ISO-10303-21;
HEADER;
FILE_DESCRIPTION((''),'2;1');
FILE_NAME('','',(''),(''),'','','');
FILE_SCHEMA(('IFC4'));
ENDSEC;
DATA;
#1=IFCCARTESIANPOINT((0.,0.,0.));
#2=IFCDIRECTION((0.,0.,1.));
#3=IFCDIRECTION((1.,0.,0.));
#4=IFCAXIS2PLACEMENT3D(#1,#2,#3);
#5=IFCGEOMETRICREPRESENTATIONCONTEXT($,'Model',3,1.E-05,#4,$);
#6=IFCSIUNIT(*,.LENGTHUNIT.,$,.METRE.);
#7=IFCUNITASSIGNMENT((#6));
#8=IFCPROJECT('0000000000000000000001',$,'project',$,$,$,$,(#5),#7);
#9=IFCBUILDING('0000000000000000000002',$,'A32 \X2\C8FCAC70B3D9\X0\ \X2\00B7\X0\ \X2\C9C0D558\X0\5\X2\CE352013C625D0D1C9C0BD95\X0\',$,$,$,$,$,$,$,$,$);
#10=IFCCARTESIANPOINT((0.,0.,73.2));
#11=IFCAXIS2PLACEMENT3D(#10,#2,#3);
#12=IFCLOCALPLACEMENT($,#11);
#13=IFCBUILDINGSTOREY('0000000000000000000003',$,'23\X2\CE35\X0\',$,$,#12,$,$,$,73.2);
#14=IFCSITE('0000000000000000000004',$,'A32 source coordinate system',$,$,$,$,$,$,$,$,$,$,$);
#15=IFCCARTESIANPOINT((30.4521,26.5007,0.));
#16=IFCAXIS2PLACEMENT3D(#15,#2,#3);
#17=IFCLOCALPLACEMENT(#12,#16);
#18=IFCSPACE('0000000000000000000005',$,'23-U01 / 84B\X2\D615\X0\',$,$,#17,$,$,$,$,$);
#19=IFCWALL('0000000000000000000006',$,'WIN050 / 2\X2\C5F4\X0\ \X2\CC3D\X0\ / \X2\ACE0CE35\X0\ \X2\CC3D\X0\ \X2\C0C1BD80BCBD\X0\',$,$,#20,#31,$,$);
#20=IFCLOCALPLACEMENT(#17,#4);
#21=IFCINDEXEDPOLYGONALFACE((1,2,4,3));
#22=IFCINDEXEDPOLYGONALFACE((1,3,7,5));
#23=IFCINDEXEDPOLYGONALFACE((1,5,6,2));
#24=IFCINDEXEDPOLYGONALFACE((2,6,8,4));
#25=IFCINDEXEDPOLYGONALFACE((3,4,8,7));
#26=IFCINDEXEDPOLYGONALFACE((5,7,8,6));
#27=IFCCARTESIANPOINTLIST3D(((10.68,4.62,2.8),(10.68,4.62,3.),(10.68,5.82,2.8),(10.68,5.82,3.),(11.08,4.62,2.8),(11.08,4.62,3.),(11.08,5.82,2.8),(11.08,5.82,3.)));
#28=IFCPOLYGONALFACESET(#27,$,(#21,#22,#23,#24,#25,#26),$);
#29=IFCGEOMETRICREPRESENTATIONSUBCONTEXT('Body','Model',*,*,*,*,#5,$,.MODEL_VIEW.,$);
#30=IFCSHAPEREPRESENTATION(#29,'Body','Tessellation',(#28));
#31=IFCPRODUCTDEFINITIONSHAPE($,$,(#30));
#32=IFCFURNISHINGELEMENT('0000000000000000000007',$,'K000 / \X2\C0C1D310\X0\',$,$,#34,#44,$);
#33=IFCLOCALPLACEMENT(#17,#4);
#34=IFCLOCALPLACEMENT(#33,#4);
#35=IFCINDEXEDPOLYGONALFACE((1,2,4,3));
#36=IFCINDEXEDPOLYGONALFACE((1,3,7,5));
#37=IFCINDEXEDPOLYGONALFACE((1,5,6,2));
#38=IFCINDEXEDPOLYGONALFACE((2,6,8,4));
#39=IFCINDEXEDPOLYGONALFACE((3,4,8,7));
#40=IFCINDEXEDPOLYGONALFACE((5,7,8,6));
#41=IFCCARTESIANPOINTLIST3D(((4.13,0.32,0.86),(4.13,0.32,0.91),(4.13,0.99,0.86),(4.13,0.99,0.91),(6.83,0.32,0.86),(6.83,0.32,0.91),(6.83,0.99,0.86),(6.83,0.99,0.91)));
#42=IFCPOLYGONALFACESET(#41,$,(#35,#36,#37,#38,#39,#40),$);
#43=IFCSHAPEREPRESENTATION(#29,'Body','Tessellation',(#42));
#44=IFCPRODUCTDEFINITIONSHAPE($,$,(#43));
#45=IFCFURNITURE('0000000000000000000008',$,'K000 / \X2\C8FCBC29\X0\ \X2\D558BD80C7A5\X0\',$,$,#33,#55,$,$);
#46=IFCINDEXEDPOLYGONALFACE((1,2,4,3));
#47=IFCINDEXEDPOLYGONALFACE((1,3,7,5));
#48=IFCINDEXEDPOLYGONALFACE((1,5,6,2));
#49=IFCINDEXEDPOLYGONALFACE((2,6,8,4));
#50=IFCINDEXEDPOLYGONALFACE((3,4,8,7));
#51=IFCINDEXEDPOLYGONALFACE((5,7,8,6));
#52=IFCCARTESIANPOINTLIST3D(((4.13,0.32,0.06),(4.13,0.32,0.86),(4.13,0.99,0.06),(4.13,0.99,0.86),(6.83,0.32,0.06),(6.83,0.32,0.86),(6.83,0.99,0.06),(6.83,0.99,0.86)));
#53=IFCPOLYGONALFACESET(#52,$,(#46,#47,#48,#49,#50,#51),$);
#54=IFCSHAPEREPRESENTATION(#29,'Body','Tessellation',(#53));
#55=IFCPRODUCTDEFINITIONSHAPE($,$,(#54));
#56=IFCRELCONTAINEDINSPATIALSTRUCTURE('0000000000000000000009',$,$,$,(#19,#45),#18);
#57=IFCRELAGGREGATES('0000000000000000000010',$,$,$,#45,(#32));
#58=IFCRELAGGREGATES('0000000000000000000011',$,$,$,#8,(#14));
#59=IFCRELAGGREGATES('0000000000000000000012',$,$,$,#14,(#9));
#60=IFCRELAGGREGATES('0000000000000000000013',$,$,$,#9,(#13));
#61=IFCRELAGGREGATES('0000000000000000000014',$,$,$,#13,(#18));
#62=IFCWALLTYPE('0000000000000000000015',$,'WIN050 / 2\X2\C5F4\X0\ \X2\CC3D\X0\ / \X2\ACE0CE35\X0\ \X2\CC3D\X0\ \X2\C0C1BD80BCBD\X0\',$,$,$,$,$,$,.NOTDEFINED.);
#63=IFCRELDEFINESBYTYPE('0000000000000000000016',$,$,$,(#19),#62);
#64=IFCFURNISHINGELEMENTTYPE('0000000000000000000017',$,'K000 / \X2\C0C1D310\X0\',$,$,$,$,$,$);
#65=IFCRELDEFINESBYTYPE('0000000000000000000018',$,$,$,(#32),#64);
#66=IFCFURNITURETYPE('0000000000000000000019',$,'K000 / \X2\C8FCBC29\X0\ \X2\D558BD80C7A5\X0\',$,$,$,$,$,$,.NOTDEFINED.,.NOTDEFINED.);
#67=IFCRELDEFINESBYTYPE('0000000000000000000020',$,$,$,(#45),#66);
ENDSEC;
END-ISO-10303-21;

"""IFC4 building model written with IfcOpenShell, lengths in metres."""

from ifc_helpers import new_model, si_unit, frame, origin, origin_with_axes, place, context, subcontext, project, spatial, polyline, outline, extrude, source, transform, mapped, type_object, type_shapes, element, aggregate, save


model = new_model("IFC4")

# Units and contexts
model_context = context("Model", 3, precision=1e-05, world=origin_with_axes())
body_context = subcontext(model_context, "Body", "Model", "MODEL_VIEW")
ifc_project = project(units=[si_unit("LENGTHUNIT", "METRE")], contexts=[model_context])

# Site, building, storey, space
site = spatial("IfcSite", under=ifc_project, Name="A32 source coordinate system")
building = spatial("IfcBuilding", under=site, Name="A32 주거동 · 지하5층–옥탑지붕")
storey_placement = place(None, frame((0.0, 0.0, 73.2), z_axis=(0.0, 0.0, 1.0), x_axis=(1.0, 0.0, 0.0)))
storey = spatial("IfcBuildingStorey", under=building, at=storey_placement, Name="23층", Elevation=73.2)
space_placement = place(storey_placement, frame((30.4521, 26.5007, 0.0), z_axis=(0.0, 0.0, 1.0), x_axis=(1.0, 0.0, 0.0)))
space = spatial("IfcSpace", under=storey, at=space_placement, Name="23-U01 / 84B형")

# Wall
wall_type_1 = type_object("IfcWallType", Name="WIN050 / 2열 창 / 고층 창 상부벽", PredefinedType="NOTDEFINED")
shared_shape_1 = source(origin(), body_context, "Body", "SweptSolid", [
    extrude(outline(polyline([(11.08, 4.62), (11.08, 5.82), (10.68, 5.82), (10.68, 4.62), (11.08, 4.62)])), frame((0.0, 0.0, 2.8)), (0.0, 0.0, 1.0), 0.2),
])
type_shapes(wall_type_1, [shared_shape_1])
wall_1_placement = place(space_placement, origin_with_axes())
element("IfcWall", 1, at=wall_1_placement, inside=space, type_object=wall_type_1, Name="WIN050 / 2열 창 / 고층 창 상부벽", context=body_context, shape_type="MappedRepresentation", body=[
    mapped(shared_shape_1, transform((0.0, 0.0, 0.0), scale=1.0)),
])

# Furnishing element
furnishing_element_type = type_object("IfcFurnishingElementType", Name="K000 / 상판")
shared_shape_2 = source(origin(), body_context, "Body", "SweptSolid", [
    extrude(outline(polyline([(4.13, 0.32), (4.13, 0.99), (6.83, 0.99), (6.83, 0.32), (4.13, 0.32)])), frame((0.0, 0.0, 0.86)), (0.0, 0.0, 1.0), 0.05),
])
type_shapes(furnishing_element_type, [shared_shape_2])
furniture_placement = place(space_placement, origin_with_axes())
furnishing_placement = place(furniture_placement, origin_with_axes())
furnishing = element("IfcFurnishingElement", 2, at=furnishing_placement, type_object=furnishing_element_type, Name="K000 / 상판", context=body_context, shape_type="MappedRepresentation", body=[
    mapped(shared_shape_2, transform((0.0, 0.0, 0.0), scale=1.0)),
])

# Furniture
furniture_type = type_object("IfcFurnitureType", Name="K000 / 주방 하부장", AssemblyPlace="NOTDEFINED", PredefinedType="NOTDEFINED")
shared_shape_3 = source(origin(), body_context, "Body", "SweptSolid", [
    extrude(outline(polyline([(6.83, 0.32), (4.13, 0.32), (4.13, 0.99), (6.83, 0.99), (6.83, 0.32)])), frame((0.0, 0.0, 0.06)), (0.0, 0.0, 1.0), 0.8),
])
type_shapes(furniture_type, [shared_shape_3])
furniture = element("IfcFurniture", 3, at=furniture_placement, inside=space, type_object=furniture_type, Name="K000 / 주방 하부장", context=body_context, shape_type="MappedRepresentation", body=[
    mapped(shared_shape_3, transform((0.0, 0.0, 0.0), scale=1.0)),
])
aggregate(furniture, [furnishing])

save(model, "model.ifc")
